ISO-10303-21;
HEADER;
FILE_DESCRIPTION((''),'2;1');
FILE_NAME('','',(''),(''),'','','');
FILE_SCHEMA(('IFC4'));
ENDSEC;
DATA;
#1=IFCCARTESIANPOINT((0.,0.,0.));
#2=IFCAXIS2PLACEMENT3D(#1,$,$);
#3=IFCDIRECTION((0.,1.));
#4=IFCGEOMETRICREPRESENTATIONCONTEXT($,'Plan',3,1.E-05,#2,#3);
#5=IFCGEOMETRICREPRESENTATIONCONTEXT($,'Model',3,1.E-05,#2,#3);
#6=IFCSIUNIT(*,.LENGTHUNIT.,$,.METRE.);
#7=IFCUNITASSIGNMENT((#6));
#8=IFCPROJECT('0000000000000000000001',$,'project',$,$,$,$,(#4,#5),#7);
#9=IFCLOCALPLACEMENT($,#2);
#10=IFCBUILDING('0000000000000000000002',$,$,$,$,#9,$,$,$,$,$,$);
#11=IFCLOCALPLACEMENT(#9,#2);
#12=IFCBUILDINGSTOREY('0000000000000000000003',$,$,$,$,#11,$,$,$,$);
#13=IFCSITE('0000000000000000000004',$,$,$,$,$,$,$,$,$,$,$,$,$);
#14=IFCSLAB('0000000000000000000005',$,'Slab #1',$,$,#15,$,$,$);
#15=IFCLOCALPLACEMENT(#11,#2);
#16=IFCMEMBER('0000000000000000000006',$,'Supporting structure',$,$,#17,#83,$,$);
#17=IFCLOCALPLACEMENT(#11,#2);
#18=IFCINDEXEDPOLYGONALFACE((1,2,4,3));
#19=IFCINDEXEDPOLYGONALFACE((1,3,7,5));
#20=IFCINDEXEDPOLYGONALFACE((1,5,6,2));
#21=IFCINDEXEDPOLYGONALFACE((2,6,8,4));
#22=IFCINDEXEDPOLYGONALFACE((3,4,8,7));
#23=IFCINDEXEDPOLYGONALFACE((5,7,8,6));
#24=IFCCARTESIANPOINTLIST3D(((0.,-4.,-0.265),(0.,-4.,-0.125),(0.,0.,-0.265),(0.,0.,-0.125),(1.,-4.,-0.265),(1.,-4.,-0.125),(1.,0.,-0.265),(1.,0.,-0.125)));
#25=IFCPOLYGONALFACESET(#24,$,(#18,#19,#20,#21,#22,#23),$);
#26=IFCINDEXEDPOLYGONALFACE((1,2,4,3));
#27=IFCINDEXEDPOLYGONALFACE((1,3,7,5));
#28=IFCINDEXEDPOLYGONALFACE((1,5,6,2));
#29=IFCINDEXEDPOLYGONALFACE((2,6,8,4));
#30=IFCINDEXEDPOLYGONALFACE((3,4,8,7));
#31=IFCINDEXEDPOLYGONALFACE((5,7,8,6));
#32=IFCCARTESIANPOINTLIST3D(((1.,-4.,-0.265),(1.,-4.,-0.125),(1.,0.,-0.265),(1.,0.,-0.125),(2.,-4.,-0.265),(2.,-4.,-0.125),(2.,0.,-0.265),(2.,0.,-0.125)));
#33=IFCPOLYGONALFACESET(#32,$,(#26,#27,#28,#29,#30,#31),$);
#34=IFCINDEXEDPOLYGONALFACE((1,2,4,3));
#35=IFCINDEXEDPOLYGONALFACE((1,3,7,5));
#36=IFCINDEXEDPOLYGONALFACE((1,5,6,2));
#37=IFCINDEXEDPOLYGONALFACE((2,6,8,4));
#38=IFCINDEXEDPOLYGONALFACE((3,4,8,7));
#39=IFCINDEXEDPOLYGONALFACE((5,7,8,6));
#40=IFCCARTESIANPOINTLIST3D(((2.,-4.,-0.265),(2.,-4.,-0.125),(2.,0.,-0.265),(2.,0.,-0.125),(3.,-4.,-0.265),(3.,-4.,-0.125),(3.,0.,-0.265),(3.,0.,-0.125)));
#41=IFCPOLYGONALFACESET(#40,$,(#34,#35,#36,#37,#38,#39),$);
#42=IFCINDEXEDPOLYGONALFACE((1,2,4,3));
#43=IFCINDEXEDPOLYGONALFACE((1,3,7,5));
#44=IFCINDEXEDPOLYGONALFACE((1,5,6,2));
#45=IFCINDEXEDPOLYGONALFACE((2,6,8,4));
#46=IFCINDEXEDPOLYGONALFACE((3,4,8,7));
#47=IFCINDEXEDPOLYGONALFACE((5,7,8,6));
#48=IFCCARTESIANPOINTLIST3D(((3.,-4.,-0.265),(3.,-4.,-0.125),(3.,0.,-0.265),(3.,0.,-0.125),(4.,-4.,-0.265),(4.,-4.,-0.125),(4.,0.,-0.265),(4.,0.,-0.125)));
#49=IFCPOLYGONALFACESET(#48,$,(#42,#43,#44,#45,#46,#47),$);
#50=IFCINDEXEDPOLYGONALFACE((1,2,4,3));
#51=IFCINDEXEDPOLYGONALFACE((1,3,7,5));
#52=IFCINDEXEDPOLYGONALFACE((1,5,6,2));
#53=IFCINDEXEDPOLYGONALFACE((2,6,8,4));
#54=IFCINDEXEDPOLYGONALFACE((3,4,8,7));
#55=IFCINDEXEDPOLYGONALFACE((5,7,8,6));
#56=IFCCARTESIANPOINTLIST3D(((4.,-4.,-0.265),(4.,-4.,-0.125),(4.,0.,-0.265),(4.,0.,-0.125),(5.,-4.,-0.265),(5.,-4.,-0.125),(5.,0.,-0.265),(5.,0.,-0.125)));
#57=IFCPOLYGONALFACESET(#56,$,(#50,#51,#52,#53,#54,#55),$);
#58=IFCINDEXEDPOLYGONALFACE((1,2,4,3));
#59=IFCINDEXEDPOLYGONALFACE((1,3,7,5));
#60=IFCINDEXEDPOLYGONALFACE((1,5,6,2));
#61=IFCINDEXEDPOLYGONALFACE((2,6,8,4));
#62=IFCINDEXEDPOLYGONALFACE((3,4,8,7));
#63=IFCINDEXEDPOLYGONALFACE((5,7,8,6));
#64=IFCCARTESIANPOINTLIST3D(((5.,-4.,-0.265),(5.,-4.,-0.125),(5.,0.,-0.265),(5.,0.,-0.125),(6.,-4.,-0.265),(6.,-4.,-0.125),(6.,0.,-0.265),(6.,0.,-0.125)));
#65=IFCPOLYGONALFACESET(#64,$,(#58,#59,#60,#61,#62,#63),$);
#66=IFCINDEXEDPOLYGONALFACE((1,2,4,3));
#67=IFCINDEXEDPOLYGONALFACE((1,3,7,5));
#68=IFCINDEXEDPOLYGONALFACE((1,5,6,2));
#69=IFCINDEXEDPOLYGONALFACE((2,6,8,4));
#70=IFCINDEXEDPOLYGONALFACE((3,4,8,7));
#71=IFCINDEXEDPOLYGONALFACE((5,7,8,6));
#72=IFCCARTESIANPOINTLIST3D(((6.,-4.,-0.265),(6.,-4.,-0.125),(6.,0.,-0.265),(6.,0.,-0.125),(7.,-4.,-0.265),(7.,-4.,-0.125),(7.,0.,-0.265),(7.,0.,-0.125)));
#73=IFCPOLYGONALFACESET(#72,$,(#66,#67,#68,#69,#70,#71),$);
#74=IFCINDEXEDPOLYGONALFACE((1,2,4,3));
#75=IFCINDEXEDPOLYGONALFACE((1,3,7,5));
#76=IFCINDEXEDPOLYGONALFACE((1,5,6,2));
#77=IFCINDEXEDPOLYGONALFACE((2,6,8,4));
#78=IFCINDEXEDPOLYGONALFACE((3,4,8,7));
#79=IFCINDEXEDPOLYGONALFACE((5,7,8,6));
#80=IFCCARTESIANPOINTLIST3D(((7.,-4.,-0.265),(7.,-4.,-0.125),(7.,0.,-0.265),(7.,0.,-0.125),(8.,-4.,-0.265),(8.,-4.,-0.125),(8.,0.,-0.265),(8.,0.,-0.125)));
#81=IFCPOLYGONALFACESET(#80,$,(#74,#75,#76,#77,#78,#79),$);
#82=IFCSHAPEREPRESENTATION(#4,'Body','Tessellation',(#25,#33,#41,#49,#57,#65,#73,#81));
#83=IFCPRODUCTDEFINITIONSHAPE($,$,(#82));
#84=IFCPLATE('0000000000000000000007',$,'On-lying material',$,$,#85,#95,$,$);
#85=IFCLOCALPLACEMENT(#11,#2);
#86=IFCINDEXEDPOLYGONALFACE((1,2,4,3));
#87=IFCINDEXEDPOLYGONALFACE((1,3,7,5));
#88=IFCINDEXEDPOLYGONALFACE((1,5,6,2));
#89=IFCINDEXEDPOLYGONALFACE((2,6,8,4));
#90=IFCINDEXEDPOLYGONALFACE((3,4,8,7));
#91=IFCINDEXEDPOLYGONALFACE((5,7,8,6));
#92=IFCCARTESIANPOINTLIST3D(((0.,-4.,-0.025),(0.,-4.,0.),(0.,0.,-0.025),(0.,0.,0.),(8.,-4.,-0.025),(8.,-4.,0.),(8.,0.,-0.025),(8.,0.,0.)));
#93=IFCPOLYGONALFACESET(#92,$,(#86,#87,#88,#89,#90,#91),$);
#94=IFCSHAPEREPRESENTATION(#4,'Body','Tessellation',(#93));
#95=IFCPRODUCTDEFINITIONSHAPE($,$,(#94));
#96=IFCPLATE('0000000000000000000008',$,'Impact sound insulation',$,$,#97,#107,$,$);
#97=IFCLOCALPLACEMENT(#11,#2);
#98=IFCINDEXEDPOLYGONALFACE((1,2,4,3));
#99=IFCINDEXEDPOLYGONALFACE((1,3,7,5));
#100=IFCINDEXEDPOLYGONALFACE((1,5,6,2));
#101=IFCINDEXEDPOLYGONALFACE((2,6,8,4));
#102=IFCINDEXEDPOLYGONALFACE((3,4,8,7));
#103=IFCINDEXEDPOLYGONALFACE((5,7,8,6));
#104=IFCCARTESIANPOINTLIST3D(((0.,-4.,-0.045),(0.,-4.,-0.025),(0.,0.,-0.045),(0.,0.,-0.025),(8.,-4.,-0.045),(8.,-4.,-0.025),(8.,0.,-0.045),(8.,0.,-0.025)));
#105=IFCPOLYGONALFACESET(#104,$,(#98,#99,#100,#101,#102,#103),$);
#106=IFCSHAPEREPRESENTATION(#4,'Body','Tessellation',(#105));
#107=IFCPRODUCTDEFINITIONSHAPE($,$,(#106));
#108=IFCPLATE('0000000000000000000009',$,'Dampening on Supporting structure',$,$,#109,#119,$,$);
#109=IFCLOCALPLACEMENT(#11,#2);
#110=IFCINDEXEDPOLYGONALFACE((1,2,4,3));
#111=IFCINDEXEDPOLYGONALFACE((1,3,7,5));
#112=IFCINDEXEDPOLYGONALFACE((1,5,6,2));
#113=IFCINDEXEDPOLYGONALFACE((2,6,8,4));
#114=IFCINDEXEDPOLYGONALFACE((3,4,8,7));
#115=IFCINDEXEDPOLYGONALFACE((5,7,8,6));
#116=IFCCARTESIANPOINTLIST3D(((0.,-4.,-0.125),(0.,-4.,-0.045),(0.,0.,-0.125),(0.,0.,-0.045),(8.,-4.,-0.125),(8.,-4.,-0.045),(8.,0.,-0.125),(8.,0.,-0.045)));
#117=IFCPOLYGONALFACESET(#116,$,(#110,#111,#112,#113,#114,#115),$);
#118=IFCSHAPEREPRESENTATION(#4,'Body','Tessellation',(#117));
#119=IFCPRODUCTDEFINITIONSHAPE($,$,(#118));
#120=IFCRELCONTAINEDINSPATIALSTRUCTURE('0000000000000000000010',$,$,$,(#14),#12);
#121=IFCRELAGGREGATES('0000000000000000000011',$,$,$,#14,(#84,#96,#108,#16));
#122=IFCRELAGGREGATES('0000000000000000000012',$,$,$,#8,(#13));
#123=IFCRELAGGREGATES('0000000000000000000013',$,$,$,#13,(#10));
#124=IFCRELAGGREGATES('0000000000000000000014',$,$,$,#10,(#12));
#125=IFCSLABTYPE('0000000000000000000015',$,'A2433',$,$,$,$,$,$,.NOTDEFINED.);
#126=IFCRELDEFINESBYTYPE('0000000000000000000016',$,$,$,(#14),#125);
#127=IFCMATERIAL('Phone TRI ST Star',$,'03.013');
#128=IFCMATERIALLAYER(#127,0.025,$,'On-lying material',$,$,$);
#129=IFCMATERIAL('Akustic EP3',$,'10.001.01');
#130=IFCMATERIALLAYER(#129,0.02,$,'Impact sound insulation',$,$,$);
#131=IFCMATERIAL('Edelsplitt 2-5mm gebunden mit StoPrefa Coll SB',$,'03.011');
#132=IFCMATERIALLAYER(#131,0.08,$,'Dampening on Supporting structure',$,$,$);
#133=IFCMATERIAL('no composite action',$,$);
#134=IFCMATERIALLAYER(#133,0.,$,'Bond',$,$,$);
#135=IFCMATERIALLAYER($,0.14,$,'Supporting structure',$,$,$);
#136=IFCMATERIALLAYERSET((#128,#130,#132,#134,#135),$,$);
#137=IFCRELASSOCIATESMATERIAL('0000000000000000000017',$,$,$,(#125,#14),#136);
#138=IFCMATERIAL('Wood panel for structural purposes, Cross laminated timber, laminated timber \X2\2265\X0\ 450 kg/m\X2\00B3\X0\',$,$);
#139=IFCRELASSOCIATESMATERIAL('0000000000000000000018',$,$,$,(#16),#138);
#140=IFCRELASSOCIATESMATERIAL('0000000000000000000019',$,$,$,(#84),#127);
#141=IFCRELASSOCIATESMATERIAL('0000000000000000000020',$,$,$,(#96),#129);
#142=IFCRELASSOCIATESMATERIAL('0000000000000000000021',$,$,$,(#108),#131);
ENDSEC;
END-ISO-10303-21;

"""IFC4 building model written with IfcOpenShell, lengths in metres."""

from ifc_helpers import new_model, si_unit, direction, frame, frame_2d, origin, origin_with_axes, place, context, project, spatial, rectangle, extrude, material, layer, layer_set, type_object, element, aggregate, save


model = new_model("IFC4")

# Units and contexts
plan_context = context("Plan", 3, precision=1e-05, world=origin(), true_north=direction((0.0, 1.0)))
model_context = context("Model", 3, precision=1e-05, world=origin(), true_north=direction((0.0, 1.0)))
ifc_project = project(units=[si_unit("LENGTHUNIT", "METRE")], contexts=[plan_context, model_context])

# Site, building, storey
site = spatial("IfcSite", under=ifc_project)
building_placement = place(None, origin())
building = spatial("IfcBuilding", under=site, at=building_placement)
storey_placement = place(building_placement, origin())
storey = spatial("IfcBuildingStorey", under=building, at=storey_placement)

# Slab, member, plates
ifc_material_1 = material(Name="Phone TRI ST Star", Category="03.013")
ifc_layer_1 = layer(ifc_material_1, 0.025, Name="On-lying material")
ifc_material_2 = material(Name="Akustic EP3", Category="10.001.01")
ifc_layer_2 = layer(ifc_material_2, 0.02, Name="Impact sound insulation")
ifc_material_3 = material(Name="Edelsplitt 2-5mm gebunden mit StoPrefa Coll SB", Category="03.011")
ifc_layer_3 = layer(ifc_material_3, 0.08, Name="Dampening on Supporting structure")
ifc_material_4 = material(Name="no composite action")
ifc_layer_4 = layer(ifc_material_4, 0.0, Name="Bond")
ifc_layer_5 = layer(None, 0.14, Name="Supporting structure")
ifc_layer_set = layer_set([ifc_layer_1, ifc_layer_2, ifc_layer_3, ifc_layer_4, ifc_layer_5])
slab_type = type_object("IfcSlabType", Name="A2433", PredefinedType="NOTDEFINED", material=ifc_layer_set)
slab_placement = place(None, frame((0.0, 0.0, 0.0), z_axis=(0.0, 0.0, -1.0), x_axis=(1.0, 0.0, 0.0)))
slab = element("IfcSlab", 1, at=slab_placement, inside=storey, type_object=slab_type, material=ifc_layer_set, Name="Slab #1")
ifc_material_5 = material(Name="Wood panel for structural purposes, Cross laminated timber, laminated timber ≥ 450 kg/m³")
member_placement = place(slab_placement, origin())
member = element("IfcMember", 2, at=member_placement, material=ifc_material_5, Name="Supporting structure", context=plan_context, shape_type="SweptSolid", body=[
    extrude(rectangle(XDim=1.0, YDim=0.14, at=frame_2d((0.5, 0.07), x_axis=(1.0, 0.0))), frame((0.0, 4.0, 0.125), z_axis=(0.0, -1.0, 0.0), x_axis=(1.0, 0.0, 0.0)), (0.0, 0.0, 1.0), 4.0),
    extrude(rectangle(XDim=1.0, YDim=0.14, at=frame_2d((0.5, 0.07), x_axis=(1.0, 0.0))), frame((1.0, 4.0, 0.125), z_axis=(0.0, -1.0, 0.0), x_axis=(1.0, 0.0, 0.0)), (0.0, 0.0, 1.0), 4.0),
    extrude(rectangle(XDim=1.0, YDim=0.14, at=frame_2d((0.5, 0.07), x_axis=(1.0, 0.0))), frame((2.0, 4.0, 0.125), z_axis=(0.0, -1.0, 0.0), x_axis=(1.0, 0.0, 0.0)), (0.0, 0.0, 1.0), 4.0),
    extrude(rectangle(XDim=1.0, YDim=0.14, at=frame_2d((0.5, 0.07), x_axis=(1.0, 0.0))), frame((3.0, 4.0, 0.125), z_axis=(0.0, -1.0, 0.0), x_axis=(1.0, 0.0, 0.0)), (0.0, 0.0, 1.0), 4.0),
    extrude(rectangle(XDim=1.0, YDim=0.14, at=frame_2d((0.5, 0.07), x_axis=(1.0, 0.0))), frame((4.0, 4.0, 0.125), z_axis=(0.0, -1.0, 0.0), x_axis=(1.0, 0.0, 0.0)), (0.0, 0.0, 1.0), 4.0),
    extrude(rectangle(XDim=1.0, YDim=0.14, at=frame_2d((0.5, 0.07), x_axis=(1.0, 0.0))), frame((5.0, 4.0, 0.125), z_axis=(0.0, -1.0, 0.0), x_axis=(1.0, 0.0, 0.0)), (0.0, 0.0, 1.0), 4.0),
    extrude(rectangle(XDim=1.0, YDim=0.14, at=frame_2d((0.5, 0.07), x_axis=(1.0, 0.0))), frame((6.0, 4.0, 0.125), z_axis=(0.0, -1.0, 0.0), x_axis=(1.0, 0.0, 0.0)), (0.0, 0.0, 1.0), 4.0),
    extrude(rectangle(XDim=1.0, YDim=0.14, at=frame_2d((0.5, 0.07), x_axis=(1.0, 0.0))), frame((7.0, 4.0, 0.125), z_axis=(0.0, -1.0, 0.0), x_axis=(1.0, 0.0, 0.0)), (0.0, 0.0, 1.0), 4.0),
])
plate_1_placement = place(slab_placement, origin())
plate_1 = element("IfcPlate", 3, at=plate_1_placement, material=ifc_material_1, Name="On-lying material", context=plan_context, shape_type="SweptSolid", body=[
    extrude(rectangle(XDim=8.0, YDim=4.0, at=frame_2d((4.0, 2.0), x_axis=(1.0, 0.0))), origin_with_axes(), (0.0, 0.0, 1.0), 0.025),
])
plate_2_placement = place(slab_placement, origin())
plate_2 = element("IfcPlate", 4, at=plate_2_placement, material=ifc_material_2, Name="Impact sound insulation", context=plan_context, shape_type="SweptSolid", body=[
    extrude(rectangle(XDim=8.0, YDim=4.0, at=frame_2d((4.0, 2.0), x_axis=(1.0, 0.0))), frame((0.0, 0.0, 0.025), z_axis=(0.0, 0.0, 1.0), x_axis=(1.0, 0.0, 0.0)), (0.0, 0.0, 1.0), 0.02),
])
plate_3_placement = place(slab_placement, origin())
plate_3 = element("IfcPlate", 5, at=plate_3_placement, material=ifc_material_3, Name="Dampening on Supporting structure", context=plan_context, shape_type="SweptSolid", body=[
    extrude(rectangle(XDim=8.0, YDim=4.0, at=frame_2d((4.0, 2.0), x_axis=(1.0, 0.0))), frame((0.0, 0.0, 0.045), z_axis=(0.0, 0.0, 1.0), x_axis=(1.0, 0.0, 0.0)), (0.0, 0.0, 1.0), 0.08),
])
aggregate(slab, [plate_1, plate_2, plate_3, member])

save(model, "model.ifc")
